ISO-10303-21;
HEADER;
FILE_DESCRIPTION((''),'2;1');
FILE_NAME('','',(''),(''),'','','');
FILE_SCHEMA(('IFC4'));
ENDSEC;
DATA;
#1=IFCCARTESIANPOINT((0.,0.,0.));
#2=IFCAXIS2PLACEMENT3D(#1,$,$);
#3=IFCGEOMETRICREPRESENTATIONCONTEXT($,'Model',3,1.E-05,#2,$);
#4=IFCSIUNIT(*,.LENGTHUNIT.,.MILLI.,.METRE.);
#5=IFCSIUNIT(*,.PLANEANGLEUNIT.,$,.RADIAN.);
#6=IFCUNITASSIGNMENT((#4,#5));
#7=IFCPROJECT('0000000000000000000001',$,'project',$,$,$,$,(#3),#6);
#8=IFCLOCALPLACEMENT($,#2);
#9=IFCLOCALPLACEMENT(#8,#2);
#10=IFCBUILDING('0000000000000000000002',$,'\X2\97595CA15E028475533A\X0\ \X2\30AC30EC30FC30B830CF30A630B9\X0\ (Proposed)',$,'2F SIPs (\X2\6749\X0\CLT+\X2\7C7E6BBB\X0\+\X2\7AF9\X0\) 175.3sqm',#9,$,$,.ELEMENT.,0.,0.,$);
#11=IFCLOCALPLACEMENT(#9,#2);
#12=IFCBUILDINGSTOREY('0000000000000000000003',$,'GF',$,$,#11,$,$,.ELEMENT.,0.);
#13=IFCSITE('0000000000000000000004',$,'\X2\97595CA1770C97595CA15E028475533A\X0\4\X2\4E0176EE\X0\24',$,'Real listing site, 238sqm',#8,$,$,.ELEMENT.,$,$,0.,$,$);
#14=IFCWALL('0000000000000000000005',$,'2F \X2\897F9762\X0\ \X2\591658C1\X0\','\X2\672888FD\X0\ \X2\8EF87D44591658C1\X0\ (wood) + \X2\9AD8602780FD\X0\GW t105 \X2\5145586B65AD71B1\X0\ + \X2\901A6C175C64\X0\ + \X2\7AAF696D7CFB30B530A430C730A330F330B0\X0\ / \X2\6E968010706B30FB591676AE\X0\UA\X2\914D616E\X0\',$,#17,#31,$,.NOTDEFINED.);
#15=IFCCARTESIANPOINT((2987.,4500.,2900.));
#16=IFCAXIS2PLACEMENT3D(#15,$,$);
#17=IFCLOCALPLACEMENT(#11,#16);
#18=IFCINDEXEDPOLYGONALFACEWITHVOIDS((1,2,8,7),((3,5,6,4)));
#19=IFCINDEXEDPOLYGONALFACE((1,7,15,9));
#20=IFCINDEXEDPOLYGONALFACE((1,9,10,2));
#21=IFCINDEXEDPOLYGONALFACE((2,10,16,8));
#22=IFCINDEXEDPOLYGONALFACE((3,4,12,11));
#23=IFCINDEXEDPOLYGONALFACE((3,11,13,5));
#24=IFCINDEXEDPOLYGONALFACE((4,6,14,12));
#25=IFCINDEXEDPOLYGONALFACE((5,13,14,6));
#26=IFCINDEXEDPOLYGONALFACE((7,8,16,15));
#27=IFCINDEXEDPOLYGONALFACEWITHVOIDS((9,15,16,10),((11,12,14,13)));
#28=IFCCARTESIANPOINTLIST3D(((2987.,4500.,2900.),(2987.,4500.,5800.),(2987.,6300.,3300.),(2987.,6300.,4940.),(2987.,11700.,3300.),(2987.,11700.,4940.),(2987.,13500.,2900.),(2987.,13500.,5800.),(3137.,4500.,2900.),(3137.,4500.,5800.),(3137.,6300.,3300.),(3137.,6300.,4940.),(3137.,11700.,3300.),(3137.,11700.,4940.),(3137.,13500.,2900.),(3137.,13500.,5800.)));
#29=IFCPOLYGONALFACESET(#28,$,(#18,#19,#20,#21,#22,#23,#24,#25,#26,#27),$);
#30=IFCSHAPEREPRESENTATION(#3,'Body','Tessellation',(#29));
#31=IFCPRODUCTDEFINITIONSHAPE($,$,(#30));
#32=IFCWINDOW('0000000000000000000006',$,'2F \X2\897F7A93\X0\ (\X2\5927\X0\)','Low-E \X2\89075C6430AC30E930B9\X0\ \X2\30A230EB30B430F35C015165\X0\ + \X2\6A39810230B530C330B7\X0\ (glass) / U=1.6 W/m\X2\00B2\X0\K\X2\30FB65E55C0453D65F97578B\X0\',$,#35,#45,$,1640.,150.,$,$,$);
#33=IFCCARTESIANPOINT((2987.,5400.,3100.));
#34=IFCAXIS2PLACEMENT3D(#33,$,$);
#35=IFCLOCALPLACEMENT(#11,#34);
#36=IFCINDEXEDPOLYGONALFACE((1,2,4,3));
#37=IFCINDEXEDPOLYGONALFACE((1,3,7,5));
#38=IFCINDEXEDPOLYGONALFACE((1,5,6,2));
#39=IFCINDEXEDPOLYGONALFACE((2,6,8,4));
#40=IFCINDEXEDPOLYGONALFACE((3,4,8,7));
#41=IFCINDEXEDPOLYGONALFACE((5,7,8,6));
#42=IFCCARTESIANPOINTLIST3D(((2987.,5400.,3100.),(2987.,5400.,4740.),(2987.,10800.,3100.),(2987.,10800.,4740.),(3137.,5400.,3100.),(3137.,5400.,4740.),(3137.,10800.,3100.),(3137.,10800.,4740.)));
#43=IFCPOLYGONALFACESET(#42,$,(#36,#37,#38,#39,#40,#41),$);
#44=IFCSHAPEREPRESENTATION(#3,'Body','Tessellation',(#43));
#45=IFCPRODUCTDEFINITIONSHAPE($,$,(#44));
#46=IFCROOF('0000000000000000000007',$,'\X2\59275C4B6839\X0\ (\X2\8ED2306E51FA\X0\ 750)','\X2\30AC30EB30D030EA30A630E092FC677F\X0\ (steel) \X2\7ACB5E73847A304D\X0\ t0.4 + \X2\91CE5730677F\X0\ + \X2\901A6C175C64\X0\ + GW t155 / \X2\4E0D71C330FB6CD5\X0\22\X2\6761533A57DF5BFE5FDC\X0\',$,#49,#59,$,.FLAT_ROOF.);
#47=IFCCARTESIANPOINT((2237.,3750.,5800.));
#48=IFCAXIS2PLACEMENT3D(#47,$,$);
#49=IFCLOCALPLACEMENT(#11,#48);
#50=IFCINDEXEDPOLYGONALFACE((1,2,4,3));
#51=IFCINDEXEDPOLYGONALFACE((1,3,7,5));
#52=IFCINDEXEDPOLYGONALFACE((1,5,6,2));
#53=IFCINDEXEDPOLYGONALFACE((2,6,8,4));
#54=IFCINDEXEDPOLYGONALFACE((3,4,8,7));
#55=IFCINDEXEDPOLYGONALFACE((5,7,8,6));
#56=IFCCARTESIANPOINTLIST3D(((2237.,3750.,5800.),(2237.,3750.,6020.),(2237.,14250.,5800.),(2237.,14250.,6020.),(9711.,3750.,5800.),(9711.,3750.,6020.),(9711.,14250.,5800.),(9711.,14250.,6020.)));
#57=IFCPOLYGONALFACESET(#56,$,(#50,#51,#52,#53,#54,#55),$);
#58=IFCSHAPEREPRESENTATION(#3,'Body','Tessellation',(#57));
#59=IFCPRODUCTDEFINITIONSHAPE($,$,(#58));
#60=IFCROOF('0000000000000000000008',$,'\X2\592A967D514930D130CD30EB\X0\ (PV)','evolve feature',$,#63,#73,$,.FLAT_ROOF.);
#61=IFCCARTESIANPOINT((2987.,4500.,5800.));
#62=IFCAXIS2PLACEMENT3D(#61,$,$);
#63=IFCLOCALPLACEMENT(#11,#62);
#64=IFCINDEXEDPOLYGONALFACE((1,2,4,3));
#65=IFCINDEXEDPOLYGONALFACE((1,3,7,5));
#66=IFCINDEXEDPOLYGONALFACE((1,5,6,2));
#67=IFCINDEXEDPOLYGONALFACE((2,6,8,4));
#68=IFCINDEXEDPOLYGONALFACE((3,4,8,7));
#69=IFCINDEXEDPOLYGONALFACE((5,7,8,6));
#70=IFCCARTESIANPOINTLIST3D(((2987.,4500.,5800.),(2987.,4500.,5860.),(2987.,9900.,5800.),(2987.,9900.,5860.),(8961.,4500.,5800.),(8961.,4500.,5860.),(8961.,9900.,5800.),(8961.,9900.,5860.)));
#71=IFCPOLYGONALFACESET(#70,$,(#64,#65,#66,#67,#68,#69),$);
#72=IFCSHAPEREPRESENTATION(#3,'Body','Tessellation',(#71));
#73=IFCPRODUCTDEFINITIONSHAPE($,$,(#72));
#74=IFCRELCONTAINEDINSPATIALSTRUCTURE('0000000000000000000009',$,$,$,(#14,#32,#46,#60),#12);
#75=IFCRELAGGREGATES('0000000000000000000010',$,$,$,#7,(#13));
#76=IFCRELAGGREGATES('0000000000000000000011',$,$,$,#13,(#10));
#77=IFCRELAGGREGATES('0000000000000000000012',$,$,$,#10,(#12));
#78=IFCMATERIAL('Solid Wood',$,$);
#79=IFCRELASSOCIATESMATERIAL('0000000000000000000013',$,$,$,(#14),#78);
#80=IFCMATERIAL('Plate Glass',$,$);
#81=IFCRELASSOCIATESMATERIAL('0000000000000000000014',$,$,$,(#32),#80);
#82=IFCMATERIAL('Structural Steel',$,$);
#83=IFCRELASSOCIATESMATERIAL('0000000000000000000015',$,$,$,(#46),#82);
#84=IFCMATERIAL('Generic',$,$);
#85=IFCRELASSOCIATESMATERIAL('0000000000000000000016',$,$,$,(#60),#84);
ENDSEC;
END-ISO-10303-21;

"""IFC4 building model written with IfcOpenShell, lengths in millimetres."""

from ifc_helpers import new_model, si_unit, frame, frame_2d, origin, place, context, project, spatial, rectangle, extrude, material, element, fill, save


model = new_model("IFC4")

# Units and contexts
model_context = context("Model", 3, precision=1e-05, world=origin())
ifc_project = project(units=[si_unit("LENGTHUNIT", "METRE", prefix="MILLI"), si_unit("PLANEANGLEUNIT", "RADIAN")], contexts=[model_context])

# Site, building, storey
site_placement = place(None, origin())
site = spatial("IfcSite", under=ifc_project, at=site_placement, Name="静岡県静岡市葵区4丁目24", ObjectType="Real listing site, 238sqm", CompositionType="ELEMENT", RefElevation=0.0)
building_placement = place(site_placement, origin())
building = spatial("IfcBuilding", under=site, at=building_placement, Name="静岡市葵区 ガレージハウス (Proposed)", ObjectType="2F SIPs (杉CLT+籾殻+竹) 175.3sqm", CompositionType="ELEMENT", ElevationOfRefHeight=0.0, ElevationOfTerrain=0.0)
storey_placement = place(building_placement, origin())
storey = spatial("IfcBuildingStorey", under=building, at=storey_placement, Name="GF", CompositionType="ELEMENT", Elevation=0.0)

# Shared definitions
ifc_material_1 = material(Name="Solid Wood")
ifc_material_2 = material(Name="Generic")

# Shared definitions
ifc_material_3 = material(Name="Plate Glass")

# Wall, opening, window
wall_1_placement = place(storey_placement, frame((2987.0, 4500.0, 2900.0)))
wall_1 = element("IfcWall", 1, at=wall_1_placement, inside=storey, material=ifc_material_1, Name="2F 西面 外壁", Description="木製 軸組外壁 (wood) + 高性能GW t105 充填断熱 + 通気層 + 窯業系サイディング / 準耐火・外皮UA配慮", PredefinedType="NOTDEFINED", context=model_context, shape_type="SweptSolid", body=[
    extrude(rectangle(XDim=150.0, YDim=9000.0, at=frame_2d((75.0, 4500.0))), frame((2987.0, 4500.0, 2900.0)), (0.0, 0.0, 1.0), 2900.0),
])
opening_1_placement = place(storey_placement, frame((2987.0, 5400.0, 3100.0)))
opening_1 = element("IfcOpeningElement", 2, at=opening_1_placement, cuts=wall_1, PredefinedType="NOTDEFINED", context=model_context, shape_type="SweptSolid", body=[
    extrude(rectangle(XDim=150.0, YDim=5400.0, at=frame_2d((75.0, 2700.0))), frame((2987.0, 5400.0, 3100.0)), (0.0, 0.0, 1.0), 1640.0),
])
window_1_placement = place(storey_placement, frame((2987.0, 5400.0, 3100.0)))
window_1 = element("IfcWindow", 3, at=window_1_placement, inside=storey, material=ifc_material_3, Name="2F 西窓 (大)", Description="Low-E 複層ガラス アルゴン封入 + 樹脂サッシ (glass) / U=1.6 W/m²K・日射取得型", OverallHeight=1640.0, OverallWidth=150.0, context=model_context, shape_type="SweptSolid", body=[
    extrude(rectangle(XDim=150.0, YDim=5400.0, at=frame_2d((75.0, 2700.0))), frame((2987.0, 5400.0, 3100.0)), (0.0, 0.0, 1.0), 1640.0),
])
fill(opening_1, window_1)

# Roofs
ifc_material_4 = material(Name="Structural Steel")
roof_1_placement = place(storey_placement, frame((2237.0, 3750.0, 5800.0)))
element("IfcRoof", 4, at=roof_1_placement, inside=storey, material=ifc_material_4, Name="大屋根 (軒の出 750)", Description="ガルバリウム鋼板 (steel) 立平葺き t0.4 + 野地板 + 通気層 + GW t155 / 不燃・法22条区域対応", PredefinedType="FLAT_ROOF", context=model_context, shape_type="SweptSolid", body=[
    extrude(rectangle(XDim=7474.0, YDim=10500.0, at=frame_2d((3737.0, 5250.0))), frame((2237.0, 3750.0, 5800.0)), (0.0, 0.0, 1.0), 220.0),
])
roof_2_placement = place(storey_placement, frame((2987.0, 4500.0, 5800.0)))
element("IfcRoof", 5, at=roof_2_placement, inside=storey, material=ifc_material_2, Name="太陽光パネル (PV)", Description="evolve feature", PredefinedType="FLAT_ROOF", context=model_context, shape_type="SweptSolid", body=[
    extrude(rectangle(XDim=5974.0, YDim=5400.0, at=frame_2d((2987.0, 2700.0))), frame((2987.0, 4500.0, 5800.0)), (0.0, 0.0, 1.0), 60.0),
])

save(model, "model.ifc")
